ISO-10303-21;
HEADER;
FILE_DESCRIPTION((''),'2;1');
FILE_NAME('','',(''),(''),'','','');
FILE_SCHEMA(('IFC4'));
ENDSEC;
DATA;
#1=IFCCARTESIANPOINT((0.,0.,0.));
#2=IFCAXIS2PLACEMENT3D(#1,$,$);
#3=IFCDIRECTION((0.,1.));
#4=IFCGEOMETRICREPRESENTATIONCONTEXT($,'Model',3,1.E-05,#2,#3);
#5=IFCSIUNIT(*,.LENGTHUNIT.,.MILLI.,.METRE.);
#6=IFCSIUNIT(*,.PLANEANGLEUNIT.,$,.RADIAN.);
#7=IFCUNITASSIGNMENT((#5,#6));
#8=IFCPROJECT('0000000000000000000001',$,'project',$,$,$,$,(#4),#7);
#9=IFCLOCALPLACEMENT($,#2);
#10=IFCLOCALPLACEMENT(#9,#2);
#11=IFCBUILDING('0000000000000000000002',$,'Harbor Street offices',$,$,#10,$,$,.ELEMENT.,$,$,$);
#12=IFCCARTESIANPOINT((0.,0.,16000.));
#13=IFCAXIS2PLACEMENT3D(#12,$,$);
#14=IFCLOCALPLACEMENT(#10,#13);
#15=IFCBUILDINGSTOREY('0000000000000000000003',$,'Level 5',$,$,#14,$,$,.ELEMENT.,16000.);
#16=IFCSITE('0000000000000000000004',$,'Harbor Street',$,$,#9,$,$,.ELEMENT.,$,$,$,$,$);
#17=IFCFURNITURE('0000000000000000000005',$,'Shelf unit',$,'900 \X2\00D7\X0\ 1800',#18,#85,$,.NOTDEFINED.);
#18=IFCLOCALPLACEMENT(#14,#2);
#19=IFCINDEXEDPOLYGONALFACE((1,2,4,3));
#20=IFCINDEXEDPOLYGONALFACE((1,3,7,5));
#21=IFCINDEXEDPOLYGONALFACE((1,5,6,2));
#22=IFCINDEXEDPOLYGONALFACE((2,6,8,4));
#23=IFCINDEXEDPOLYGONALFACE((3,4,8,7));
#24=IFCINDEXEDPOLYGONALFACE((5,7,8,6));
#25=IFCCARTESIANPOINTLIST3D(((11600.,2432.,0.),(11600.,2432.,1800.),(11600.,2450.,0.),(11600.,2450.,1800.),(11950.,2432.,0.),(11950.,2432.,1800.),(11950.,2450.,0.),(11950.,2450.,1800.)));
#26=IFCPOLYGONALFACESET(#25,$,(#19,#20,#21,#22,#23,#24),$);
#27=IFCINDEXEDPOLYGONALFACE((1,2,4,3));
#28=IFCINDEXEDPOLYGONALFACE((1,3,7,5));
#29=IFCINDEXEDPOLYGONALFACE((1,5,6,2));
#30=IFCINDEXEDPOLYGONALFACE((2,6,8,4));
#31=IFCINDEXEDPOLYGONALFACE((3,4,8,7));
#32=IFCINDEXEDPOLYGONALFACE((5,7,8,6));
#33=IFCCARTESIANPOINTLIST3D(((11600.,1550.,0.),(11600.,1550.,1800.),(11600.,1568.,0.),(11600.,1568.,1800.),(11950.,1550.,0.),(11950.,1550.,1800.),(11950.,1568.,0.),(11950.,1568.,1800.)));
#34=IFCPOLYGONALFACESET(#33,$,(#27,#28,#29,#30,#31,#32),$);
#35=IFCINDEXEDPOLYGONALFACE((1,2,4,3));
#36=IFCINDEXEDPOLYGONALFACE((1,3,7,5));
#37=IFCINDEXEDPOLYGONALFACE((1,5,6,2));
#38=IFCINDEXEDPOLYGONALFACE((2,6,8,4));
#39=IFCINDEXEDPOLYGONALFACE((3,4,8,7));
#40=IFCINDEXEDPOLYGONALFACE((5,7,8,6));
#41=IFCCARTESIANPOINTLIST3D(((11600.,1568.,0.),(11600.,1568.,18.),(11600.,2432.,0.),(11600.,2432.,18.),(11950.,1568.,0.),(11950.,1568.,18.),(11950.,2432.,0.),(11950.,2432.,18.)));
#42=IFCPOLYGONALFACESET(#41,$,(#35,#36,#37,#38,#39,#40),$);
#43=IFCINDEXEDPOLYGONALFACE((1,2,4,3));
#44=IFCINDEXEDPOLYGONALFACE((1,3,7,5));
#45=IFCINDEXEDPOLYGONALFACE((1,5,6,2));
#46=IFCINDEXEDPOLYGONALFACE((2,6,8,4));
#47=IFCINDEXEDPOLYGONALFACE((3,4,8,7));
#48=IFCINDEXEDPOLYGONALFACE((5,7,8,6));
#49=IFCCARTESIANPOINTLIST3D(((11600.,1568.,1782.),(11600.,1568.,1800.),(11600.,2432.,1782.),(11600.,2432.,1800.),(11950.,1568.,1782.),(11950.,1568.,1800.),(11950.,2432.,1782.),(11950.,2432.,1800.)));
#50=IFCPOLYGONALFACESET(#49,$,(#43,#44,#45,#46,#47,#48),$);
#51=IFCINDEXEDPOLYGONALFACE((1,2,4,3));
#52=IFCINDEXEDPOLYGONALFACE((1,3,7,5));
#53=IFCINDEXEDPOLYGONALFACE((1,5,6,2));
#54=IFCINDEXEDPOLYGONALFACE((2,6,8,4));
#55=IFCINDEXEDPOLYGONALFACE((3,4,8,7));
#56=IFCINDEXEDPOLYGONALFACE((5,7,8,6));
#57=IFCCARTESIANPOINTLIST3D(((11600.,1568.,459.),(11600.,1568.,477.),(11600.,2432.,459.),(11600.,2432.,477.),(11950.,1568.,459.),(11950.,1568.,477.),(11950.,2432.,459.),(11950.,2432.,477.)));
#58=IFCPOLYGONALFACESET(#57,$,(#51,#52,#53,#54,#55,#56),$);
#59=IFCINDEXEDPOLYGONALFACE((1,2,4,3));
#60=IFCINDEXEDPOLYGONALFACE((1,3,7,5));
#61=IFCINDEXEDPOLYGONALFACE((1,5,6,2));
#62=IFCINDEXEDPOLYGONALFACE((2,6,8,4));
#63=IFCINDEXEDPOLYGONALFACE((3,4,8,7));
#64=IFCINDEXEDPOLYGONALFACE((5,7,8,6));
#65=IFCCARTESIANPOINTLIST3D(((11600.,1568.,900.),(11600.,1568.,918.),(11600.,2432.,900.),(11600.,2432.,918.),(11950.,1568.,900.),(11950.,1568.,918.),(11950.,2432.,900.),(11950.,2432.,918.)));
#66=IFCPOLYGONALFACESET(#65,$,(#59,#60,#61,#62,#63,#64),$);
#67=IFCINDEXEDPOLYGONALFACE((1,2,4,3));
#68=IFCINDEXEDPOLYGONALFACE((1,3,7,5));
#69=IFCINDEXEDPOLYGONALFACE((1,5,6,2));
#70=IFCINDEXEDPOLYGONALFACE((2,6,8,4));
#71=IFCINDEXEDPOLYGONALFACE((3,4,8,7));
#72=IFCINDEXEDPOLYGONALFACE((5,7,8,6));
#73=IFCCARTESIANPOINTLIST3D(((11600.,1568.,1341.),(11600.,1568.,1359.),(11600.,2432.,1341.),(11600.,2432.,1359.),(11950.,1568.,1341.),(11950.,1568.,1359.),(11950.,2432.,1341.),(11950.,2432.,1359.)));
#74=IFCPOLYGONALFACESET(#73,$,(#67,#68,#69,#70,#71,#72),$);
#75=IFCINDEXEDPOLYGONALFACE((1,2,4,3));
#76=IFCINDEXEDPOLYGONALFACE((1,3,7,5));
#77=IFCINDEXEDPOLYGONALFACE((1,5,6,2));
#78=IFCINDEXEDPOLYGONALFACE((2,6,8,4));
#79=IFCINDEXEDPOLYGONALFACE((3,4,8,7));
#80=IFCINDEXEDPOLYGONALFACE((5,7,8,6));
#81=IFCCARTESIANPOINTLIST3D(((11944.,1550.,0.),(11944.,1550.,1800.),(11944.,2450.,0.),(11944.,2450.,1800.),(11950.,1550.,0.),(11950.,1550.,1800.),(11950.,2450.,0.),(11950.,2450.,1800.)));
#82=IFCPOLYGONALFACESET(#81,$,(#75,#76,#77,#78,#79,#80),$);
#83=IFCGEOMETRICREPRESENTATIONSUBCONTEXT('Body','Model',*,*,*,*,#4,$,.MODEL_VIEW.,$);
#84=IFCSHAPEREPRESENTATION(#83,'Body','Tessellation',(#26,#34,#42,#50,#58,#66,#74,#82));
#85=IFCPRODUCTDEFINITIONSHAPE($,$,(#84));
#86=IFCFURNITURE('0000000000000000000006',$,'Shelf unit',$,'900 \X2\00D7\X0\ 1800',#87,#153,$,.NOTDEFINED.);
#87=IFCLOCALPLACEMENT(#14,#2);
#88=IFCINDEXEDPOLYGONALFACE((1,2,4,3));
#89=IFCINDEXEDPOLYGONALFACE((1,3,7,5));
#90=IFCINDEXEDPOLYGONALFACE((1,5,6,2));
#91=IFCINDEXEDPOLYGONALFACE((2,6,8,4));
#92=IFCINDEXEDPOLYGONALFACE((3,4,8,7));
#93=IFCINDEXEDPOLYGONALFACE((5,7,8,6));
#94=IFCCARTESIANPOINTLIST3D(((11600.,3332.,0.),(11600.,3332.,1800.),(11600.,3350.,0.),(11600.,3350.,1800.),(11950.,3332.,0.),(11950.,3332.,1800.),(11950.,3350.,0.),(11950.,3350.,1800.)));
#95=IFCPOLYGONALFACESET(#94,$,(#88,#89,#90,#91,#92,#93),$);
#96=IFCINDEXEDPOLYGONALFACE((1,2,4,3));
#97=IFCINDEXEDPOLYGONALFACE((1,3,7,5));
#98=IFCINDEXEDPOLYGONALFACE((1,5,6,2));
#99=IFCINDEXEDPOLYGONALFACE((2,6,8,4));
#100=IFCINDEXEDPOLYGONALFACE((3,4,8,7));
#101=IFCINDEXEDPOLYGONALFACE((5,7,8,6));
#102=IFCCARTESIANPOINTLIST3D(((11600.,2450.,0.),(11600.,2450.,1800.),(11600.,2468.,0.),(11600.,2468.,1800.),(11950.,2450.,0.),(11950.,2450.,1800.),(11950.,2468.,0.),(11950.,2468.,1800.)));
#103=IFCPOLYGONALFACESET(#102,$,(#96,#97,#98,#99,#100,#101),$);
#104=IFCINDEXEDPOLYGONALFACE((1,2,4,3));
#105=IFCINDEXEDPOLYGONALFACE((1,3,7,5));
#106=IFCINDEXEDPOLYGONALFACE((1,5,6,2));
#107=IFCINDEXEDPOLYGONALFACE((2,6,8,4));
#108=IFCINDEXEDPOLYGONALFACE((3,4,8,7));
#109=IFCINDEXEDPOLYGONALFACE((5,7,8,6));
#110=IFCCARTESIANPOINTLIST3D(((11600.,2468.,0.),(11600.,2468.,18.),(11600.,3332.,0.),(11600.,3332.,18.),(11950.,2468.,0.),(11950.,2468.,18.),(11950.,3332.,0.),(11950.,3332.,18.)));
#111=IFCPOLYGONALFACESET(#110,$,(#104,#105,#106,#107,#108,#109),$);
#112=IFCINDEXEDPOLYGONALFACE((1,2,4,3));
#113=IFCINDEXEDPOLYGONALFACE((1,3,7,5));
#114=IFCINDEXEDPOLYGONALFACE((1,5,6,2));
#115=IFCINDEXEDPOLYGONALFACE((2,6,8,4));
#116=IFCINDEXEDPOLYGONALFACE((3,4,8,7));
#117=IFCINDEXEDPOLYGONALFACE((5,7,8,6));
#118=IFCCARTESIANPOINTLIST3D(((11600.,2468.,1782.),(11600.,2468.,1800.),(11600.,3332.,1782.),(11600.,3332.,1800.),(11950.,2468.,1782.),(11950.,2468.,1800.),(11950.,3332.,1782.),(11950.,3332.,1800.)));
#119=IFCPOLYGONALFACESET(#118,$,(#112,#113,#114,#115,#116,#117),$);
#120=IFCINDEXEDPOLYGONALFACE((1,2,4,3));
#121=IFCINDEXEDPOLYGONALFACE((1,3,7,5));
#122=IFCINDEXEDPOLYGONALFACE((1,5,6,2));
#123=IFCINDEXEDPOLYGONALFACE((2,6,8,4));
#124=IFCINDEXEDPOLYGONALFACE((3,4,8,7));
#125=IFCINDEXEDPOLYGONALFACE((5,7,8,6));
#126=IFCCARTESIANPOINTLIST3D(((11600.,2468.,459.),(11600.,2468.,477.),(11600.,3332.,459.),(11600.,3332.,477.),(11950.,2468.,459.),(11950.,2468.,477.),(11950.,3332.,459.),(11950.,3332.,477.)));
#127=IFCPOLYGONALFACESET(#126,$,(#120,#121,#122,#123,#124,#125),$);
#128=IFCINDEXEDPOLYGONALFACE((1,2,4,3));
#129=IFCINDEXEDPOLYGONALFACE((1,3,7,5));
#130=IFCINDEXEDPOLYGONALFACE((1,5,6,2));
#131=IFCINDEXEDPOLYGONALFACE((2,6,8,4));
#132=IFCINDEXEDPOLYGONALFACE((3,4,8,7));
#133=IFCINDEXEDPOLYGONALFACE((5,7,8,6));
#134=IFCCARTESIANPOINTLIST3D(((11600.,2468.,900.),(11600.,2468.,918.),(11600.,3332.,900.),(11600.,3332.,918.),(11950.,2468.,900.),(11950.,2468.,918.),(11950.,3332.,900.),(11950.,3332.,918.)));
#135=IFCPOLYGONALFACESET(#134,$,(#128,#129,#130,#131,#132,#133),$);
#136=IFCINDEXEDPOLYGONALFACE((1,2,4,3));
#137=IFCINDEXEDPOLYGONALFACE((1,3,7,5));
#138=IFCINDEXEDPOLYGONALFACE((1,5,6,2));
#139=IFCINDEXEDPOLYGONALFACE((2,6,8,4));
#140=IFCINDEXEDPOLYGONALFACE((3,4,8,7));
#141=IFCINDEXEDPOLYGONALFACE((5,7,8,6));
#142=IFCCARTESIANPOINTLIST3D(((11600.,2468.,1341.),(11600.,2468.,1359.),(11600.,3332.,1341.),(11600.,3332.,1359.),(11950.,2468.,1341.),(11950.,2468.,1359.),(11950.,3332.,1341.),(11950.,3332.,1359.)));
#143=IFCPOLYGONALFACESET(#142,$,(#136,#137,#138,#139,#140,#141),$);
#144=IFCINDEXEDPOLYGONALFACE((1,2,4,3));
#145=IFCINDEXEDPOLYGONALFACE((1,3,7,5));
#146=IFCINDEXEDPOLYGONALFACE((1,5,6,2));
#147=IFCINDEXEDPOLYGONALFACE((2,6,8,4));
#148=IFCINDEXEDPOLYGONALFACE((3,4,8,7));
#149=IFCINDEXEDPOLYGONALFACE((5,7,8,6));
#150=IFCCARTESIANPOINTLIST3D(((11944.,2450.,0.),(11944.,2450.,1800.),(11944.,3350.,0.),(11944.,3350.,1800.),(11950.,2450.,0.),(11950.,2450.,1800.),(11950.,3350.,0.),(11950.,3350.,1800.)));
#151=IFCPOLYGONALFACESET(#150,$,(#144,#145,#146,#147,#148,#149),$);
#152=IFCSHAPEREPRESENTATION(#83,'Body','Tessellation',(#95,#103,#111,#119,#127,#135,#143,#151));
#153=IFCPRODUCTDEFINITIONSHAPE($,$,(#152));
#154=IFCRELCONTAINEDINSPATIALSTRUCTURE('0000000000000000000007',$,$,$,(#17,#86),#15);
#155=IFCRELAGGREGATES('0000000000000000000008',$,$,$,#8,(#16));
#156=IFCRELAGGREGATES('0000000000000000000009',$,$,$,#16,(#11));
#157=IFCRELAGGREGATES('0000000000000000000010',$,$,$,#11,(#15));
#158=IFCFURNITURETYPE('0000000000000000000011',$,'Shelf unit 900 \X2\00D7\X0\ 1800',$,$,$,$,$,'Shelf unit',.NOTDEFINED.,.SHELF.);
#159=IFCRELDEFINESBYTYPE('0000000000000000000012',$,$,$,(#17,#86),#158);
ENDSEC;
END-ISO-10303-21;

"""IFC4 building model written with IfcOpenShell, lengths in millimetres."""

from ifc_helpers import new_model, si_unit, direction, frame, origin, place, context, subcontext, project, spatial, polyline, outline, extrude, source, transform, mapped, type_object, type_shapes, element, save


model = new_model("IFC4")

# Units and contexts
model_context = context("Model", 3, precision=1e-05, world=origin(), true_north=direction((0.0, 1.0)))
body_context = subcontext(model_context, "Body", "Model", "MODEL_VIEW")
ifc_project = project(units=[si_unit("LENGTHUNIT", "METRE", prefix="MILLI"), si_unit("PLANEANGLEUNIT", "RADIAN")], contexts=[model_context])

# Site, building, storey
site_placement = place(None, origin())
site = spatial("IfcSite", under=ifc_project, at=site_placement, Name="Harbor Street", CompositionType="ELEMENT")
building_placement = place(site_placement, origin())
building = spatial("IfcBuilding", under=site, at=building_placement, Name="Harbor Street offices", CompositionType="ELEMENT")
storey_placement = place(building_placement, frame((0.0, 0.0, 16000.0)))
storey = spatial("IfcBuildingStorey", under=building, at=storey_placement, Name="Level 5", CompositionType="ELEMENT", Elevation=16000.0)

# Furniture
furniture_type_1 = type_object("IfcFurnitureType", Name="Shelf unit 900 × 1800", ElementType="Shelf unit", AssemblyPlace="NOTDEFINED", PredefinedType="SHELF")
shared_shape_1 = source(origin(), body_context, "Body", "SweptSolid", [
    extrude(outline(polyline([(-450.0, 0.0), (-432.0, 0.0), (-432.0, 350.0), (-450.0, 350.0), (-450.0, 0.0)])), origin(), (0.0, 0.0, 1.0), 1800.0),
    extrude(outline(polyline([(432.0, 0.0), (450.0, 0.0), (450.0, 350.0), (432.0, 350.0), (432.0, 0.0)])), origin(), (0.0, 0.0, 1.0), 1800.0),
    extrude(outline(polyline([(-432.0, 0.0), (432.0, 0.0), (432.0, 350.0), (-432.0, 350.0), (-432.0, 0.0)])), origin(), (0.0, 0.0, 1.0), 18.0),
    extrude(outline(polyline([(-432.0, 0.0), (432.0, 0.0), (432.0, 350.0), (-432.0, 350.0), (-432.0, 0.0)])), frame((0.0, 0.0, 1782.0)), (0.0, 0.0, 1.0), 18.0),
    extrude(outline(polyline([(-432.0, 0.0), (432.0, 0.0), (432.0, 350.0), (-432.0, 350.0), (-432.0, 0.0)])), frame((0.0, 0.0, 459.0)), (0.0, 0.0, 1.0), 18.0),
    extrude(outline(polyline([(-432.0, 0.0), (432.0, 0.0), (432.0, 350.0), (-432.0, 350.0), (-432.0, 0.0)])), frame((0.0, 0.0, 900.0)), (0.0, 0.0, 1.0), 18.0),
    extrude(outline(polyline([(-432.0, 0.0), (432.0, 0.0), (432.0, 350.0), (-432.0, 350.0), (-432.0, 0.0)])), frame((0.0, 0.0, 1341.0)), (0.0, 0.0, 1.0), 18.0),
    extrude(outline(polyline([(-450.0, 344.0), (450.0, 344.0), (450.0, 350.0), (-450.0, 350.0), (-450.0, 344.0)])), origin(), (0.0, 0.0, 1.0), 1800.0),
])
type_shapes(furniture_type_1, [shared_shape_1])
for number, where, z_axis, x_axis, name in (
    (1, (11600.0, 2000.0, 0.0), (0.0, 0.0, 1.0), (0.0, -1.0, 0.0), "Shelf unit"),
    (2, (11600.0, 2900.0, 0.0), (0.0, 0.0, 1.0), (0.0, -1.0, 0.0), "Shelf unit"),
):
    element("IfcFurniture", number, at=place(storey_placement, frame(where, z_axis=z_axis, x_axis=x_axis)), inside=storey, type_object=furniture_type_1, Name=name, ObjectType="900 × 1800", PredefinedType="NOTDEFINED", context=body_context, shape_type="MappedRepresentation", body=[
        mapped(shared_shape_1, transform((0.0, 0.0, 0.0))),
    ])

save(model, "model.ifc")
